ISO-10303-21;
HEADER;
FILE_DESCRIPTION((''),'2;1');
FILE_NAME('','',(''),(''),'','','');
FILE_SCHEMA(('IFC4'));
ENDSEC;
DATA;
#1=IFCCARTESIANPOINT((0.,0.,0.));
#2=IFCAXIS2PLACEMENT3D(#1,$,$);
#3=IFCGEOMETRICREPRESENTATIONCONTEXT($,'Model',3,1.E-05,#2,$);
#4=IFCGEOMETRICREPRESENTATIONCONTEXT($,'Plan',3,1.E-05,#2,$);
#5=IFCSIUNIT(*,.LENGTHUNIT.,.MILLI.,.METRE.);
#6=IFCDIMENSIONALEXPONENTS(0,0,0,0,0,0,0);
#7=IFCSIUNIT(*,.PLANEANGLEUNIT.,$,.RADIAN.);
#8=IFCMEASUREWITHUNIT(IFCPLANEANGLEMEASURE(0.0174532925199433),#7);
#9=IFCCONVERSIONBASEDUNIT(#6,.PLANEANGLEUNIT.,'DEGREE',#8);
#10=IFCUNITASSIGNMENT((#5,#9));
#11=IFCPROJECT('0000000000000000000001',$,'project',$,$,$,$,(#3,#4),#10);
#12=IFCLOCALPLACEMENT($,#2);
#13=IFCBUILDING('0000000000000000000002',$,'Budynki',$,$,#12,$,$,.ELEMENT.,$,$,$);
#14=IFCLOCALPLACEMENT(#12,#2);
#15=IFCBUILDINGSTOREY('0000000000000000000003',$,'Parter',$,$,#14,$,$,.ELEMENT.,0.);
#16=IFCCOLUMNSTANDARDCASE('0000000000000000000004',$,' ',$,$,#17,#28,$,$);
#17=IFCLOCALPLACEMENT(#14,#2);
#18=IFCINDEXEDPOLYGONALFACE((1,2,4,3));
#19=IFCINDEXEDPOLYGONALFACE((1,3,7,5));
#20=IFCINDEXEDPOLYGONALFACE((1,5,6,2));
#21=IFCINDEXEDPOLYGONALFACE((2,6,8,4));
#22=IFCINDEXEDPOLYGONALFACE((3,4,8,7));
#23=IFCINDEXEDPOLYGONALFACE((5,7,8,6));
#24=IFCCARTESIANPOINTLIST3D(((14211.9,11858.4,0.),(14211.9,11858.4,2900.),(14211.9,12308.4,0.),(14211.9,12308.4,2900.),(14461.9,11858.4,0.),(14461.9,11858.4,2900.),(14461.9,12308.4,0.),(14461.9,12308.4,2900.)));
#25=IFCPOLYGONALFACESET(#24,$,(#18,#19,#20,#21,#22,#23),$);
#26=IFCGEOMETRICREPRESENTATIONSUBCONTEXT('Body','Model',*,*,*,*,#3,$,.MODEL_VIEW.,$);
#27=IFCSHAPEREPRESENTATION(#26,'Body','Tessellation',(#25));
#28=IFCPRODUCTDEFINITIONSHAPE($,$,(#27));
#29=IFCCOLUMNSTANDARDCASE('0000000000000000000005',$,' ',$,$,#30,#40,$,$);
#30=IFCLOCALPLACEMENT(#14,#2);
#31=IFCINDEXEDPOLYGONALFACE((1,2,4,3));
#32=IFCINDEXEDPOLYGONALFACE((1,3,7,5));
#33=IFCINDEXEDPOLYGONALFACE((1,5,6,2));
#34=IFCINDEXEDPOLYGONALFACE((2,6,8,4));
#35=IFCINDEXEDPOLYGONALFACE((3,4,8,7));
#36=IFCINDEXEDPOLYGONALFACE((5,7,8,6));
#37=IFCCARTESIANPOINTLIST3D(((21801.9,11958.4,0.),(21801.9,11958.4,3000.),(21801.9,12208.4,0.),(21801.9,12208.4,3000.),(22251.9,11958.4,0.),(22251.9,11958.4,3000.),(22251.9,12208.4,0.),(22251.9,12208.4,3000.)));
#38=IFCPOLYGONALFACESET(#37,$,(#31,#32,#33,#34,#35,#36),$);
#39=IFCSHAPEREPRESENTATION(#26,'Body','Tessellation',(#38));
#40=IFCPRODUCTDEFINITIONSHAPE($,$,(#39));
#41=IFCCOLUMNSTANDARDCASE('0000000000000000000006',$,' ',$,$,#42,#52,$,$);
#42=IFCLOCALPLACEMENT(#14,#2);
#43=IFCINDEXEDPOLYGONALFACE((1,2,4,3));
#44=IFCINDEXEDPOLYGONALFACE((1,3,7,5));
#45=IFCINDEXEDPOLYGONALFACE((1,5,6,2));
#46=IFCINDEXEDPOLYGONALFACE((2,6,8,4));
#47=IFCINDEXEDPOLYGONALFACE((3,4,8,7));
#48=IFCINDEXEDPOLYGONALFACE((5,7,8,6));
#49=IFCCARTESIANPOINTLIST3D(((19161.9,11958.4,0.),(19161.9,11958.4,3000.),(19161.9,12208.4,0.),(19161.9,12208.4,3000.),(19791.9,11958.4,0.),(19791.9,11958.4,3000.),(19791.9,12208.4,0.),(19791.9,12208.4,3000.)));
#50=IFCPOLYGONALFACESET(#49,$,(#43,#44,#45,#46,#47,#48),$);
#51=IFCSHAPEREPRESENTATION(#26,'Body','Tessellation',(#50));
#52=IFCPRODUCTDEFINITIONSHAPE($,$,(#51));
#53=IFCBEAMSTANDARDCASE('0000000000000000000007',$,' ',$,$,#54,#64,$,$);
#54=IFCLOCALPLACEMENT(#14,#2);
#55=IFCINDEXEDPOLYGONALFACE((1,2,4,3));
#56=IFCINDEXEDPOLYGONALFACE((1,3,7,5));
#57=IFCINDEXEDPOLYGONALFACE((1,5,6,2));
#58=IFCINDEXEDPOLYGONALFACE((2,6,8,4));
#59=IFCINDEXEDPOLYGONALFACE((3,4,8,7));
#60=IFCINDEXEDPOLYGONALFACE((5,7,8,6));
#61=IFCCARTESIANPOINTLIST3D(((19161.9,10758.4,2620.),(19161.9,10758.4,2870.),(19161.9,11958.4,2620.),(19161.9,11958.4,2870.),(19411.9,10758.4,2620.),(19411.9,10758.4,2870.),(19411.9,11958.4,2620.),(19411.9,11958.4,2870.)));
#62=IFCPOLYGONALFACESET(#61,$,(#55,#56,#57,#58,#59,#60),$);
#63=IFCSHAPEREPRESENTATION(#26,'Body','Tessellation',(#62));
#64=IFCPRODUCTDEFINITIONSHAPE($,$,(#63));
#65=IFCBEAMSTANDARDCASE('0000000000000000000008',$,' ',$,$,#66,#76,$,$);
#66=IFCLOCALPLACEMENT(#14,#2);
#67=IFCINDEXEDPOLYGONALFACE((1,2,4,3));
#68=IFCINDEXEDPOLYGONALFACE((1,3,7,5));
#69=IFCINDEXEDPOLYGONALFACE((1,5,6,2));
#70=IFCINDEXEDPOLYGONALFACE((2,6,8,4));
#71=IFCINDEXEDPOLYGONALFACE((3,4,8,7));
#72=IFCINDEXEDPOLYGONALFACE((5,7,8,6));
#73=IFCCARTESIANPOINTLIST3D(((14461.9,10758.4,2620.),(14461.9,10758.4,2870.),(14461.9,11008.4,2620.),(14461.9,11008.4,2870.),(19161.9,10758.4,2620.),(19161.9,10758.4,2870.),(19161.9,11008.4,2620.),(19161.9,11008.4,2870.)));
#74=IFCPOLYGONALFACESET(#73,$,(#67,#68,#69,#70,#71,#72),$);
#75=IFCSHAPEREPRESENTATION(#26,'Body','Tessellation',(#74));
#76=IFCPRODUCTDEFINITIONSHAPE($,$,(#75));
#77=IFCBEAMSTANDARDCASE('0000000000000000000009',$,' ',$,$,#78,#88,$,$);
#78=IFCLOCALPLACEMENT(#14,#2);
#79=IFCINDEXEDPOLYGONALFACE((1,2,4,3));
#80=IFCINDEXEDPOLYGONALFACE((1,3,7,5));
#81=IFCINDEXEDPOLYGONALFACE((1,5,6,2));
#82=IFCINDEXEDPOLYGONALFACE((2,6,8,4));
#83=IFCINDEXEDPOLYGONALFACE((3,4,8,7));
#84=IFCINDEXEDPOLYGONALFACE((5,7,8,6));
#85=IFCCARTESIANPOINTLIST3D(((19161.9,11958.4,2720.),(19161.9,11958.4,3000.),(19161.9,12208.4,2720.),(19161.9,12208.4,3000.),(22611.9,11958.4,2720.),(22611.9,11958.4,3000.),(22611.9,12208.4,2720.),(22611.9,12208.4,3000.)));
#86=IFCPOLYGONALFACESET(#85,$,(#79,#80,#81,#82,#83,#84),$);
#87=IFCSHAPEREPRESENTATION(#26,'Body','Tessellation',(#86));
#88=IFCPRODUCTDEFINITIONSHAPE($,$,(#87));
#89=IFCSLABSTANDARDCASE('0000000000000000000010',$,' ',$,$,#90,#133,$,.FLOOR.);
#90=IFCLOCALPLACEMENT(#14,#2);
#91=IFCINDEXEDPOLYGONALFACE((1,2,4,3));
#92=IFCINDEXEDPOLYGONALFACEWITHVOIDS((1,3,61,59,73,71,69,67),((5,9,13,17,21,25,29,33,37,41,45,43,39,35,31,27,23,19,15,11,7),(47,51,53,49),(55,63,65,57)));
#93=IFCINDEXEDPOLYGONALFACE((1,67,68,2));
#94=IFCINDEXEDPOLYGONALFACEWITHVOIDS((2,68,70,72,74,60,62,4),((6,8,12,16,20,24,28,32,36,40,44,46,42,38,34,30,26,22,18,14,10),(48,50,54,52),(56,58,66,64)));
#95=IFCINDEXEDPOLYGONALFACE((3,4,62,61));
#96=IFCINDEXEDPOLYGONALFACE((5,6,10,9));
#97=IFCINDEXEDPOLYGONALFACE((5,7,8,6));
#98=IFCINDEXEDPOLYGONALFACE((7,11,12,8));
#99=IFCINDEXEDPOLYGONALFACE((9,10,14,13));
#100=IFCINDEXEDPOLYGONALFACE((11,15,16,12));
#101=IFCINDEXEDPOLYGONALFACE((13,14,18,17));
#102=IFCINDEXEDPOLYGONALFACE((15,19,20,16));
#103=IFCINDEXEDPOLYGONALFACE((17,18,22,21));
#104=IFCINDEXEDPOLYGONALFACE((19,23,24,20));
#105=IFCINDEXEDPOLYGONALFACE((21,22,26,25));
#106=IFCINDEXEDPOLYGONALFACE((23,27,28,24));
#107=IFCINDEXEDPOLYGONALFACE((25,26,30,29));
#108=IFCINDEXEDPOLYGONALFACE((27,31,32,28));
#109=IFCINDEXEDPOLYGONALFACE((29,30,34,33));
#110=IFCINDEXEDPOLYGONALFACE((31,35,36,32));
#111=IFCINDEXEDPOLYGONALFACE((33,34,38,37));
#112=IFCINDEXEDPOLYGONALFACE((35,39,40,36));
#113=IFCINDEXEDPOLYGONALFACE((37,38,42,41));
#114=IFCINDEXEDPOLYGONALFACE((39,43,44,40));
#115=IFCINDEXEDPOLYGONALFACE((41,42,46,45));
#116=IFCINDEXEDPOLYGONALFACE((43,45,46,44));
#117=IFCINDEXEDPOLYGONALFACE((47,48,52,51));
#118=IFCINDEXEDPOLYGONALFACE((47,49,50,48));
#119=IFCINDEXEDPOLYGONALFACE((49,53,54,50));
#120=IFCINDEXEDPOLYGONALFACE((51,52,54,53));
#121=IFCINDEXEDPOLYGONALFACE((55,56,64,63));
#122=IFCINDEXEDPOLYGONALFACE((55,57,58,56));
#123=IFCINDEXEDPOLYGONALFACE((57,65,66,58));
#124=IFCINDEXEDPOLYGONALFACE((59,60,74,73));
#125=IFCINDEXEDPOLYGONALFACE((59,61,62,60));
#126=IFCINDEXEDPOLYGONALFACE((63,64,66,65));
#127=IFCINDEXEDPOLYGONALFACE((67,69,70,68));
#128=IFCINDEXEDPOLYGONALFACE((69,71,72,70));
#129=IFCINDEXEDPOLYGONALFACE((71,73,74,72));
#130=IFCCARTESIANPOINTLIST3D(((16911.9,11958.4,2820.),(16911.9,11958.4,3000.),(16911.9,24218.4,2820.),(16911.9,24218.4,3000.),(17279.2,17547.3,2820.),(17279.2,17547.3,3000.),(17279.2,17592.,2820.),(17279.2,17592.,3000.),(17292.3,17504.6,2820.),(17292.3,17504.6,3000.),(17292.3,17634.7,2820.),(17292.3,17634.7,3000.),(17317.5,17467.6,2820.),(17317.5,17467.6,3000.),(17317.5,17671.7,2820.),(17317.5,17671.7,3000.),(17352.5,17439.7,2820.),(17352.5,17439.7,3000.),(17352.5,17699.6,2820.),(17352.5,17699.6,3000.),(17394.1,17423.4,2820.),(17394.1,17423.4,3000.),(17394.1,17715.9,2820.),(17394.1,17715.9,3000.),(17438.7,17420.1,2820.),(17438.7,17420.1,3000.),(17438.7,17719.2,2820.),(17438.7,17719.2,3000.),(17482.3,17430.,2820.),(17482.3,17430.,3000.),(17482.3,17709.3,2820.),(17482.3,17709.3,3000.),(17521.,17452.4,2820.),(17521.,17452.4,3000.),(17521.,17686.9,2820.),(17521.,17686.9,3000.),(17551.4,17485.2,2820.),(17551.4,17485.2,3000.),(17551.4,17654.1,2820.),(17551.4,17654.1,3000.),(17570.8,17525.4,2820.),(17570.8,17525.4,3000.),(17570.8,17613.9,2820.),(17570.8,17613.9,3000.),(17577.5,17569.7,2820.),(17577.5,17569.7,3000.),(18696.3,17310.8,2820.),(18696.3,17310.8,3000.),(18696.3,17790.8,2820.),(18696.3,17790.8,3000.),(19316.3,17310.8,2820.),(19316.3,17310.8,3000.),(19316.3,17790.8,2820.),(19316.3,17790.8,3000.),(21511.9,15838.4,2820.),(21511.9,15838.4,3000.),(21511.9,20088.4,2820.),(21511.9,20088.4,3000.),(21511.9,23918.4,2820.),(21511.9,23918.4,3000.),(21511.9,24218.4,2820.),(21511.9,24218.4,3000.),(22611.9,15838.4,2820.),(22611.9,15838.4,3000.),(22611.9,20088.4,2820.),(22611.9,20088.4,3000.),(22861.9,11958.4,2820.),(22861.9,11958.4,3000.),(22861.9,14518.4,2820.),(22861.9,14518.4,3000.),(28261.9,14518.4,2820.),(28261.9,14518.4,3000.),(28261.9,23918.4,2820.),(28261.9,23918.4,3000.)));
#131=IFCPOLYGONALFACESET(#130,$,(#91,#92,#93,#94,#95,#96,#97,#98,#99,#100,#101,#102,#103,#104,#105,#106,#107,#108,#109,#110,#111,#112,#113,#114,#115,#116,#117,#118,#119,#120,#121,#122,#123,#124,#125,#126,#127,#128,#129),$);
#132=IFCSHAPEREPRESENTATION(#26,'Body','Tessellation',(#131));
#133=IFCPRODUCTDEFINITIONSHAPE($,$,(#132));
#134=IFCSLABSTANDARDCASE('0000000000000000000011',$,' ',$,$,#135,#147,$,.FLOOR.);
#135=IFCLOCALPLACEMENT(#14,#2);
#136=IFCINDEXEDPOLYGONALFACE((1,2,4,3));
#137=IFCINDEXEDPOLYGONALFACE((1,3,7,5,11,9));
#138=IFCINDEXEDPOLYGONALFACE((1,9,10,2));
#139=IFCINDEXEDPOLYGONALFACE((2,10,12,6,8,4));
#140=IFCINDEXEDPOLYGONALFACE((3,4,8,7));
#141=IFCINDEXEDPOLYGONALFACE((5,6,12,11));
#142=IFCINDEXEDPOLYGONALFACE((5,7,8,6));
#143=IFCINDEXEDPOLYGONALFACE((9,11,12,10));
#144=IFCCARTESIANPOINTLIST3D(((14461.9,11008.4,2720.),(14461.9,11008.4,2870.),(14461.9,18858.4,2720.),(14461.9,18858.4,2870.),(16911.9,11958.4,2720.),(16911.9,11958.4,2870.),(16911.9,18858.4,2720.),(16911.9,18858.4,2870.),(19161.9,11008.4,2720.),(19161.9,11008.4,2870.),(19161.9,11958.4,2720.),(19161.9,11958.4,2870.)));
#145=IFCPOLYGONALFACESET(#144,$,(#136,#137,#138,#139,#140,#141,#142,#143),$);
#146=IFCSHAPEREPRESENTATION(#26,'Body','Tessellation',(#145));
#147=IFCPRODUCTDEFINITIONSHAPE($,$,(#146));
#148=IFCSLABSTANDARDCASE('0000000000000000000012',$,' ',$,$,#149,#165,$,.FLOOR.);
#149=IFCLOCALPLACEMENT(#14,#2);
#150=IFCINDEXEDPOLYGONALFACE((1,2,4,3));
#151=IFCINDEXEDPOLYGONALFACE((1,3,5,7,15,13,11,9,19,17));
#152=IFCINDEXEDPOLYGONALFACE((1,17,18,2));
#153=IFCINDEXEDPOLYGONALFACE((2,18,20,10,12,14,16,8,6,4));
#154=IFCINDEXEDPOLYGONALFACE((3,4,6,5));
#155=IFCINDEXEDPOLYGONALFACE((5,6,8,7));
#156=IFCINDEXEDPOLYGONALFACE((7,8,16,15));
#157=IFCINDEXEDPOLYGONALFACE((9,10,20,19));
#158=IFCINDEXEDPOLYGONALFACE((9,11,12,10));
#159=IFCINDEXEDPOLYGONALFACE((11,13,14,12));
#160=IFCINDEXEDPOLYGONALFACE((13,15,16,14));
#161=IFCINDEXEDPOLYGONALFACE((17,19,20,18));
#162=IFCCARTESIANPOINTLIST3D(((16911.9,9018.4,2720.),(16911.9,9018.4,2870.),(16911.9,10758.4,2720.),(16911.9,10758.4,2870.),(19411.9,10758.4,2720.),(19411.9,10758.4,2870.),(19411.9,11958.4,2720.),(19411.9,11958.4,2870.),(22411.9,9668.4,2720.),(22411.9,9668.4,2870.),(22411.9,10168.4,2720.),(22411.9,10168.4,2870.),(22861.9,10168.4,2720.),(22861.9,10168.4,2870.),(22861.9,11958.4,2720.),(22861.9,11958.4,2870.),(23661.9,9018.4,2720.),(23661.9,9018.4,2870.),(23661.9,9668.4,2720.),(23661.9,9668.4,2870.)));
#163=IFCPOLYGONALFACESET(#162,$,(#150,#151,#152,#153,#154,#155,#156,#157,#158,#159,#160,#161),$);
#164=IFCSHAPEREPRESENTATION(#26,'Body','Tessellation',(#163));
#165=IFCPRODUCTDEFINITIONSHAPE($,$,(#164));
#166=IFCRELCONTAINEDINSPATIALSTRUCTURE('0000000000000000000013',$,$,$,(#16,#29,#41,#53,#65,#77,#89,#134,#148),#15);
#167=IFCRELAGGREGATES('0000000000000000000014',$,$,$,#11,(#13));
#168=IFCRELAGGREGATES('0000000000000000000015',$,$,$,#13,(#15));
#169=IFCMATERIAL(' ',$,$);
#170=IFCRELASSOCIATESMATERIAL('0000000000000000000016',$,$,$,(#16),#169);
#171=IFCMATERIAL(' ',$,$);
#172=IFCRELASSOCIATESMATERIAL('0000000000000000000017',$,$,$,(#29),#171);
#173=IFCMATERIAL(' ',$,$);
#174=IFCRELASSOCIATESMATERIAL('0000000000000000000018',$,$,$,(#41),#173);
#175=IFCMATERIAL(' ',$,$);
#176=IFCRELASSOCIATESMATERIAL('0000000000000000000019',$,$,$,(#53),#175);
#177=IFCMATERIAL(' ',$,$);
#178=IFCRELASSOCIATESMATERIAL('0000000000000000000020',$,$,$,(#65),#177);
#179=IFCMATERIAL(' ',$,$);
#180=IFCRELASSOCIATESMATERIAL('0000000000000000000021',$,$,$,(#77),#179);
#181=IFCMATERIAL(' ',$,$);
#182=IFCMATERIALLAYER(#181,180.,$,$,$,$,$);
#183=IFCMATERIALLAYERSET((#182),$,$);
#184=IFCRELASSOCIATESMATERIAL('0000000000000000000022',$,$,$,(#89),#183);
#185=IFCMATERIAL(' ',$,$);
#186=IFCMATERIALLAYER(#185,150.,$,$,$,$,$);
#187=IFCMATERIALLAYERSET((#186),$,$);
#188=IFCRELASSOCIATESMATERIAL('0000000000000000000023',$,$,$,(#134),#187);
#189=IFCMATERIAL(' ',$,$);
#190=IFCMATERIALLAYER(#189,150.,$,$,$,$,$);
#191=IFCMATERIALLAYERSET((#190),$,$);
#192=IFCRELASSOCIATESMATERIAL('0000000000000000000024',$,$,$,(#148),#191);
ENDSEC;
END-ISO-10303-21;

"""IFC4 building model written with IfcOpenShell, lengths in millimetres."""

from ifc_helpers import new_model, entity, si_unit, converted_unit, frame, frame_2d, origin, origin_with_axes, place, context, subcontext, project, spatial, polyline, rectangle, circle, outline, extrude, material, layer, layer_set, layer_usage, material_profile, profile_set, profile_usage, element, save


model = new_model("IFC4")

# Units and contexts
model_context = context("Model", 3, precision=1e-05, world=origin())
plan_context = context("Plan", 3, precision=1e-05, world=origin())
body_context = subcontext(model_context, "Body", "Model", "MODEL_VIEW")
ifc_project = project(units=[si_unit("LENGTHUNIT", "METRE", prefix="MILLI"), converted_unit("PLANEANGLEUNIT", "DEGREE", entity("IfcPlaneAngleMeasure", 0.0174532925199433), si_unit("PLANEANGLEUNIT", "RADIAN"), dimensions=[0, 0, 0, 0, 0, 0, 0])], contexts=[model_context, plan_context])

# Building, storey
building_placement = place(None, origin())
building = spatial("IfcBuilding", under=ifc_project, at=building_placement, Name="Budynki", CompositionType="ELEMENT")
storey_placement = place(building_placement, origin())
storey = spatial("IfcBuildingStorey", under=building, at=storey_placement, Name="Parter", CompositionType="ELEMENT", Elevation=0.0)

# Columns
ifc_material_1 = material(Name=" ")
ifc_material_profile_1 = material_profile(ifc_material_1, rectangle(XDim=450.0, YDim=250.0, at=frame_2d((125.0, -225.0), x_axis=(0.0, -1.0))))
ifc_profile_set_1 = profile_set([ifc_material_profile_1])
ifc_profile_usage_1 = profile_usage(ifc_profile_set_1)
column_1_placement = place(storey_placement, frame((14211.9, 11858.4, 0.0)))
element("IfcColumnStandardCase", 1, at=column_1_placement, inside=storey, material=ifc_profile_usage_1, Name=" ", context=body_context, shape_type="SweptSolid", body=[
    extrude(rectangle(XDim=450.0, YDim=250.0, at=frame_2d((125.0, -225.0), x_axis=(0.0, -1.0))), frame((0.0, 450.0, 0.0), z_axis=(0.0, 0.0, 1.0), x_axis=(1.0, 0.0, 0.0)), (0.0, 0.0, 1.0), 2900.0),
])
ifc_material_2 = material(Name=" ")
ifc_material_profile_2 = material_profile(ifc_material_2, rectangle(XDim=450.0, YDim=250.0, at=frame_2d((225.0, 125.0), x_axis=(1.0, 0.0))))
ifc_profile_set_2 = profile_set([ifc_material_profile_2])
ifc_profile_usage_2 = profile_usage(ifc_profile_set_2)
column_2_placement = place(storey_placement, frame((21801.9, 11958.4, 0.0)))
element("IfcColumnStandardCase", 2, at=column_2_placement, inside=storey, material=ifc_profile_usage_2, Name=" ", context=body_context, shape_type="SweptSolid", body=[
    extrude(rectangle(XDim=450.0, YDim=250.0, at=frame_2d((225.0, 125.0), x_axis=(1.0, 0.0))), origin_with_axes(), (0.0, 0.0, 1.0), 3000.0),
])
ifc_material_3 = material(Name=" ")
ifc_material_profile_3 = material_profile(ifc_material_3, rectangle(XDim=630.0, YDim=250.0, at=frame_2d((315.0, 125.0), x_axis=(1.0, 0.0))))
ifc_profile_set_3 = profile_set([ifc_material_profile_3])
ifc_profile_usage_3 = profile_usage(ifc_profile_set_3)
column_3_placement = place(storey_placement, frame((19161.9, 11958.4, 0.0)))
element("IfcColumnStandardCase", 3, at=column_3_placement, inside=storey, material=ifc_profile_usage_3, Name=" ", context=body_context, shape_type="SweptSolid", body=[
    extrude(rectangle(XDim=630.0, YDim=250.0, at=frame_2d((315.0, 125.0), x_axis=(1.0, 0.0))), origin_with_axes(), (0.0, 0.0, 1.0), 3000.0),
])

# Beams
ifc_material_4 = material(Name=" ")
ifc_material_profile_4 = material_profile(ifc_material_4, rectangle(XDim=250.0, YDim=250.0, at=frame_2d((125.0, -125.0), x_axis=(0.0, 1.0))))
ifc_profile_set_4 = profile_set([ifc_material_profile_4])
ifc_profile_usage_4 = profile_usage(ifc_profile_set_4)
beam_1_placement = place(storey_placement, frame((19161.9, 11958.4, 2620.0), z_axis=(0.0, 0.0, 1.0), x_axis=(0.0, -1.0, 0.0)))
element("IfcBeamStandardCase", 4, at=beam_1_placement, inside=storey, material=ifc_profile_usage_4, Name=" ", context=body_context, shape_type="SweptSolid", body=[
    extrude(rectangle(XDim=250.0, YDim=250.0, at=frame_2d((125.0, -125.0), x_axis=(0.0, 1.0))), frame((0.0, 0.0, 0.0), z_axis=(1.0, 0.0, 0.0), x_axis=(0.0, 0.0, 1.0)), (0.0, 0.0, 1.0), 1200.0),
])
ifc_material_5 = material(Name=" ")
ifc_material_profile_5 = material_profile(ifc_material_5, rectangle(XDim=250.0, YDim=250.0, at=frame_2d((125.0, -125.0), x_axis=(0.0, 1.0))))
ifc_profile_set_5 = profile_set([ifc_material_profile_5])
ifc_profile_usage_5 = profile_usage(ifc_profile_set_5)
beam_2_placement = place(storey_placement, frame((19161.9, 11008.4, 2620.0), z_axis=(0.0, 0.0, 1.0), x_axis=(-1.0, 0.0, 0.0)))
element("IfcBeamStandardCase", 5, at=beam_2_placement, inside=storey, material=ifc_profile_usage_5, Name=" ", context=body_context, shape_type="SweptSolid", body=[
    extrude(rectangle(XDim=250.0, YDim=250.0, at=frame_2d((125.0, -125.0), x_axis=(0.0, 1.0))), frame((0.0, 0.0, 0.0), z_axis=(1.0, 0.0, 0.0), x_axis=(0.0, 0.0, 1.0)), (0.0, 0.0, 1.0), 4700.0),
])
ifc_material_6 = material(Name=" ")
ifc_material_profile_6 = material_profile(ifc_material_6, rectangle(XDim=250.0, YDim=280.0, at=frame_2d((140.0, -125.0), x_axis=(0.0, 1.0))))
ifc_profile_set_6 = profile_set([ifc_material_profile_6])
ifc_profile_usage_6 = profile_usage(ifc_profile_set_6)
beam_3_placement = place(storey_placement, frame((19161.9, 11958.4, 2720.0), z_axis=(0.0, 0.0, 1.0), x_axis=(1.0, 0.0, 0.0)))
element("IfcBeamStandardCase", 6, at=beam_3_placement, inside=storey, material=ifc_profile_usage_6, Name=" ", context=body_context, shape_type="SweptSolid", body=[
    extrude(rectangle(XDim=250.0, YDim=280.0, at=frame_2d((140.0, -125.0), x_axis=(0.0, 1.0))), frame((0.0, 0.0, 0.0), z_axis=(1.0, 0.0, 0.0), x_axis=(0.0, 0.0, 1.0)), (0.0, 0.0, 1.0), 3450.0),
])

# Slab, openings
ifc_material_7 = material(Name=" ")
ifc_layer_1 = layer(ifc_material_7, 180.0)
ifc_layer_set_1 = layer_set([ifc_layer_1])
ifc_layer_usage_1 = layer_usage(ifc_layer_set_1, "AXIS3", "POSITIVE", 0.0)
slab_1_placement = place(storey_placement, frame((16911.9, 11958.4, 2820.0)))
slab_1 = element("IfcSlabStandardCase", 7, at=slab_1_placement, inside=storey, material=ifc_layer_usage_1, Name=" ", PredefinedType="FLOOR", context=body_context, shape_type="SweptSolid", body=[
    extrude(outline(polyline([(0.0, 0.0), (5950.0, 0.0), (5950.0, 2560.0), (11350.0, 2560.0), (11350.0, 11960.0), (4600.0, 11960.0), (4600.0, 12260.0), (0.0, 12260.0), (0.0, 0.0)]), holes=[polyline([(2404.4, 5832.4), (2404.4, 5352.4), (1784.4, 5352.4), (1784.4, 5832.4), (2404.4, 5832.4)])]), origin_with_axes(), (0.0, 0.0, 1.0), 180.0),
])
opening_1_placement = place(slab_1_placement, frame((366.2, 5461.9, 0.0)))
element("IfcOpeningStandardCase", 8, at=opening_1_placement, cuts=slab_1, PredefinedType="OPENING", context=body_context, shape_type="SweptSolid", body=[
    extrude(circle(Radius=150.0, at=frame_2d((0.0, 0.0), x_axis=(1.0, 0.0))), frame((149.4, 149.4, 0.0), z_axis=(0.0, 0.0, 1.0), x_axis=(1.0, 0.0, 0.0)), (0.0, 0.0, 1.0), 180.0),
])
opening_2_placement = place(slab_1_placement, frame((4600.0, 3880.0, 0.0)))
element("IfcOpeningStandardCase", 9, at=opening_2_placement, cuts=slab_1, PredefinedType="OPENING", context=body_context, shape_type="SweptSolid", body=[
    extrude(rectangle(XDim=4250.0, YDim=1100.0, at=frame_2d((0.0, 0.0), x_axis=(0.0, -1.0))), frame((550.0, 2125.0, 0.0), z_axis=(0.0, 0.0, 1.0), x_axis=(1.0, 0.0, 0.0)), (0.0, 0.0, 1.0), 180.0),
])

# Slabs
ifc_material_8 = material(Name=" ")
ifc_layer_2 = layer(ifc_material_8, 150.0)
ifc_layer_set_2 = layer_set([ifc_layer_2])
ifc_layer_usage_2 = layer_usage(ifc_layer_set_2, "AXIS3", "POSITIVE", 0.0)
slab_2_placement = place(storey_placement, frame((14461.9, 11008.4, 2720.0)))
element("IfcSlabStandardCase", 10, at=slab_2_placement, inside=storey, material=ifc_layer_usage_2, Name=" ", PredefinedType="FLOOR", context=body_context, shape_type="SweptSolid", body=[
    extrude(outline(polyline([(2450.0, 7850.0), (0.0, 7850.0), (0.0, 0.0), (4700.0, 0.0), (4700.0, 950.0), (2450.0, 950.0), (2450.0, 7850.0)])), origin_with_axes(), (0.0, 0.0, 1.0), 150.0),
])
ifc_material_9 = material(Name=" ")
ifc_layer_3 = layer(ifc_material_9, 150.0)
ifc_layer_set_3 = layer_set([ifc_layer_3])
ifc_layer_usage_3 = layer_usage(ifc_layer_set_3, "AXIS3", "POSITIVE", 0.0)
slab_3_placement = place(storey_placement, frame((16911.9, 9018.4, 2720.0)))
element("IfcSlabStandardCase", 11, at=slab_3_placement, inside=storey, material=ifc_layer_usage_3, Name=" ", PredefinedType="FLOOR", context=body_context, shape_type="SweptSolid", body=[
    extrude(outline(polyline([(6750.0, 0.0), (6750.0, 650.0), (5500.0, 650.0), (5500.0, 1150.0), (5950.0, 1150.0), (5950.0, 2940.0), (2500.0, 2940.0), (2500.0, 1740.0), (0.0, 1740.0), (0.0, 0.0), (6750.0, 0.0)])), origin_with_axes(), (0.0, 0.0, 1.0), 150.0),
])

save(model, "model.ifc")
